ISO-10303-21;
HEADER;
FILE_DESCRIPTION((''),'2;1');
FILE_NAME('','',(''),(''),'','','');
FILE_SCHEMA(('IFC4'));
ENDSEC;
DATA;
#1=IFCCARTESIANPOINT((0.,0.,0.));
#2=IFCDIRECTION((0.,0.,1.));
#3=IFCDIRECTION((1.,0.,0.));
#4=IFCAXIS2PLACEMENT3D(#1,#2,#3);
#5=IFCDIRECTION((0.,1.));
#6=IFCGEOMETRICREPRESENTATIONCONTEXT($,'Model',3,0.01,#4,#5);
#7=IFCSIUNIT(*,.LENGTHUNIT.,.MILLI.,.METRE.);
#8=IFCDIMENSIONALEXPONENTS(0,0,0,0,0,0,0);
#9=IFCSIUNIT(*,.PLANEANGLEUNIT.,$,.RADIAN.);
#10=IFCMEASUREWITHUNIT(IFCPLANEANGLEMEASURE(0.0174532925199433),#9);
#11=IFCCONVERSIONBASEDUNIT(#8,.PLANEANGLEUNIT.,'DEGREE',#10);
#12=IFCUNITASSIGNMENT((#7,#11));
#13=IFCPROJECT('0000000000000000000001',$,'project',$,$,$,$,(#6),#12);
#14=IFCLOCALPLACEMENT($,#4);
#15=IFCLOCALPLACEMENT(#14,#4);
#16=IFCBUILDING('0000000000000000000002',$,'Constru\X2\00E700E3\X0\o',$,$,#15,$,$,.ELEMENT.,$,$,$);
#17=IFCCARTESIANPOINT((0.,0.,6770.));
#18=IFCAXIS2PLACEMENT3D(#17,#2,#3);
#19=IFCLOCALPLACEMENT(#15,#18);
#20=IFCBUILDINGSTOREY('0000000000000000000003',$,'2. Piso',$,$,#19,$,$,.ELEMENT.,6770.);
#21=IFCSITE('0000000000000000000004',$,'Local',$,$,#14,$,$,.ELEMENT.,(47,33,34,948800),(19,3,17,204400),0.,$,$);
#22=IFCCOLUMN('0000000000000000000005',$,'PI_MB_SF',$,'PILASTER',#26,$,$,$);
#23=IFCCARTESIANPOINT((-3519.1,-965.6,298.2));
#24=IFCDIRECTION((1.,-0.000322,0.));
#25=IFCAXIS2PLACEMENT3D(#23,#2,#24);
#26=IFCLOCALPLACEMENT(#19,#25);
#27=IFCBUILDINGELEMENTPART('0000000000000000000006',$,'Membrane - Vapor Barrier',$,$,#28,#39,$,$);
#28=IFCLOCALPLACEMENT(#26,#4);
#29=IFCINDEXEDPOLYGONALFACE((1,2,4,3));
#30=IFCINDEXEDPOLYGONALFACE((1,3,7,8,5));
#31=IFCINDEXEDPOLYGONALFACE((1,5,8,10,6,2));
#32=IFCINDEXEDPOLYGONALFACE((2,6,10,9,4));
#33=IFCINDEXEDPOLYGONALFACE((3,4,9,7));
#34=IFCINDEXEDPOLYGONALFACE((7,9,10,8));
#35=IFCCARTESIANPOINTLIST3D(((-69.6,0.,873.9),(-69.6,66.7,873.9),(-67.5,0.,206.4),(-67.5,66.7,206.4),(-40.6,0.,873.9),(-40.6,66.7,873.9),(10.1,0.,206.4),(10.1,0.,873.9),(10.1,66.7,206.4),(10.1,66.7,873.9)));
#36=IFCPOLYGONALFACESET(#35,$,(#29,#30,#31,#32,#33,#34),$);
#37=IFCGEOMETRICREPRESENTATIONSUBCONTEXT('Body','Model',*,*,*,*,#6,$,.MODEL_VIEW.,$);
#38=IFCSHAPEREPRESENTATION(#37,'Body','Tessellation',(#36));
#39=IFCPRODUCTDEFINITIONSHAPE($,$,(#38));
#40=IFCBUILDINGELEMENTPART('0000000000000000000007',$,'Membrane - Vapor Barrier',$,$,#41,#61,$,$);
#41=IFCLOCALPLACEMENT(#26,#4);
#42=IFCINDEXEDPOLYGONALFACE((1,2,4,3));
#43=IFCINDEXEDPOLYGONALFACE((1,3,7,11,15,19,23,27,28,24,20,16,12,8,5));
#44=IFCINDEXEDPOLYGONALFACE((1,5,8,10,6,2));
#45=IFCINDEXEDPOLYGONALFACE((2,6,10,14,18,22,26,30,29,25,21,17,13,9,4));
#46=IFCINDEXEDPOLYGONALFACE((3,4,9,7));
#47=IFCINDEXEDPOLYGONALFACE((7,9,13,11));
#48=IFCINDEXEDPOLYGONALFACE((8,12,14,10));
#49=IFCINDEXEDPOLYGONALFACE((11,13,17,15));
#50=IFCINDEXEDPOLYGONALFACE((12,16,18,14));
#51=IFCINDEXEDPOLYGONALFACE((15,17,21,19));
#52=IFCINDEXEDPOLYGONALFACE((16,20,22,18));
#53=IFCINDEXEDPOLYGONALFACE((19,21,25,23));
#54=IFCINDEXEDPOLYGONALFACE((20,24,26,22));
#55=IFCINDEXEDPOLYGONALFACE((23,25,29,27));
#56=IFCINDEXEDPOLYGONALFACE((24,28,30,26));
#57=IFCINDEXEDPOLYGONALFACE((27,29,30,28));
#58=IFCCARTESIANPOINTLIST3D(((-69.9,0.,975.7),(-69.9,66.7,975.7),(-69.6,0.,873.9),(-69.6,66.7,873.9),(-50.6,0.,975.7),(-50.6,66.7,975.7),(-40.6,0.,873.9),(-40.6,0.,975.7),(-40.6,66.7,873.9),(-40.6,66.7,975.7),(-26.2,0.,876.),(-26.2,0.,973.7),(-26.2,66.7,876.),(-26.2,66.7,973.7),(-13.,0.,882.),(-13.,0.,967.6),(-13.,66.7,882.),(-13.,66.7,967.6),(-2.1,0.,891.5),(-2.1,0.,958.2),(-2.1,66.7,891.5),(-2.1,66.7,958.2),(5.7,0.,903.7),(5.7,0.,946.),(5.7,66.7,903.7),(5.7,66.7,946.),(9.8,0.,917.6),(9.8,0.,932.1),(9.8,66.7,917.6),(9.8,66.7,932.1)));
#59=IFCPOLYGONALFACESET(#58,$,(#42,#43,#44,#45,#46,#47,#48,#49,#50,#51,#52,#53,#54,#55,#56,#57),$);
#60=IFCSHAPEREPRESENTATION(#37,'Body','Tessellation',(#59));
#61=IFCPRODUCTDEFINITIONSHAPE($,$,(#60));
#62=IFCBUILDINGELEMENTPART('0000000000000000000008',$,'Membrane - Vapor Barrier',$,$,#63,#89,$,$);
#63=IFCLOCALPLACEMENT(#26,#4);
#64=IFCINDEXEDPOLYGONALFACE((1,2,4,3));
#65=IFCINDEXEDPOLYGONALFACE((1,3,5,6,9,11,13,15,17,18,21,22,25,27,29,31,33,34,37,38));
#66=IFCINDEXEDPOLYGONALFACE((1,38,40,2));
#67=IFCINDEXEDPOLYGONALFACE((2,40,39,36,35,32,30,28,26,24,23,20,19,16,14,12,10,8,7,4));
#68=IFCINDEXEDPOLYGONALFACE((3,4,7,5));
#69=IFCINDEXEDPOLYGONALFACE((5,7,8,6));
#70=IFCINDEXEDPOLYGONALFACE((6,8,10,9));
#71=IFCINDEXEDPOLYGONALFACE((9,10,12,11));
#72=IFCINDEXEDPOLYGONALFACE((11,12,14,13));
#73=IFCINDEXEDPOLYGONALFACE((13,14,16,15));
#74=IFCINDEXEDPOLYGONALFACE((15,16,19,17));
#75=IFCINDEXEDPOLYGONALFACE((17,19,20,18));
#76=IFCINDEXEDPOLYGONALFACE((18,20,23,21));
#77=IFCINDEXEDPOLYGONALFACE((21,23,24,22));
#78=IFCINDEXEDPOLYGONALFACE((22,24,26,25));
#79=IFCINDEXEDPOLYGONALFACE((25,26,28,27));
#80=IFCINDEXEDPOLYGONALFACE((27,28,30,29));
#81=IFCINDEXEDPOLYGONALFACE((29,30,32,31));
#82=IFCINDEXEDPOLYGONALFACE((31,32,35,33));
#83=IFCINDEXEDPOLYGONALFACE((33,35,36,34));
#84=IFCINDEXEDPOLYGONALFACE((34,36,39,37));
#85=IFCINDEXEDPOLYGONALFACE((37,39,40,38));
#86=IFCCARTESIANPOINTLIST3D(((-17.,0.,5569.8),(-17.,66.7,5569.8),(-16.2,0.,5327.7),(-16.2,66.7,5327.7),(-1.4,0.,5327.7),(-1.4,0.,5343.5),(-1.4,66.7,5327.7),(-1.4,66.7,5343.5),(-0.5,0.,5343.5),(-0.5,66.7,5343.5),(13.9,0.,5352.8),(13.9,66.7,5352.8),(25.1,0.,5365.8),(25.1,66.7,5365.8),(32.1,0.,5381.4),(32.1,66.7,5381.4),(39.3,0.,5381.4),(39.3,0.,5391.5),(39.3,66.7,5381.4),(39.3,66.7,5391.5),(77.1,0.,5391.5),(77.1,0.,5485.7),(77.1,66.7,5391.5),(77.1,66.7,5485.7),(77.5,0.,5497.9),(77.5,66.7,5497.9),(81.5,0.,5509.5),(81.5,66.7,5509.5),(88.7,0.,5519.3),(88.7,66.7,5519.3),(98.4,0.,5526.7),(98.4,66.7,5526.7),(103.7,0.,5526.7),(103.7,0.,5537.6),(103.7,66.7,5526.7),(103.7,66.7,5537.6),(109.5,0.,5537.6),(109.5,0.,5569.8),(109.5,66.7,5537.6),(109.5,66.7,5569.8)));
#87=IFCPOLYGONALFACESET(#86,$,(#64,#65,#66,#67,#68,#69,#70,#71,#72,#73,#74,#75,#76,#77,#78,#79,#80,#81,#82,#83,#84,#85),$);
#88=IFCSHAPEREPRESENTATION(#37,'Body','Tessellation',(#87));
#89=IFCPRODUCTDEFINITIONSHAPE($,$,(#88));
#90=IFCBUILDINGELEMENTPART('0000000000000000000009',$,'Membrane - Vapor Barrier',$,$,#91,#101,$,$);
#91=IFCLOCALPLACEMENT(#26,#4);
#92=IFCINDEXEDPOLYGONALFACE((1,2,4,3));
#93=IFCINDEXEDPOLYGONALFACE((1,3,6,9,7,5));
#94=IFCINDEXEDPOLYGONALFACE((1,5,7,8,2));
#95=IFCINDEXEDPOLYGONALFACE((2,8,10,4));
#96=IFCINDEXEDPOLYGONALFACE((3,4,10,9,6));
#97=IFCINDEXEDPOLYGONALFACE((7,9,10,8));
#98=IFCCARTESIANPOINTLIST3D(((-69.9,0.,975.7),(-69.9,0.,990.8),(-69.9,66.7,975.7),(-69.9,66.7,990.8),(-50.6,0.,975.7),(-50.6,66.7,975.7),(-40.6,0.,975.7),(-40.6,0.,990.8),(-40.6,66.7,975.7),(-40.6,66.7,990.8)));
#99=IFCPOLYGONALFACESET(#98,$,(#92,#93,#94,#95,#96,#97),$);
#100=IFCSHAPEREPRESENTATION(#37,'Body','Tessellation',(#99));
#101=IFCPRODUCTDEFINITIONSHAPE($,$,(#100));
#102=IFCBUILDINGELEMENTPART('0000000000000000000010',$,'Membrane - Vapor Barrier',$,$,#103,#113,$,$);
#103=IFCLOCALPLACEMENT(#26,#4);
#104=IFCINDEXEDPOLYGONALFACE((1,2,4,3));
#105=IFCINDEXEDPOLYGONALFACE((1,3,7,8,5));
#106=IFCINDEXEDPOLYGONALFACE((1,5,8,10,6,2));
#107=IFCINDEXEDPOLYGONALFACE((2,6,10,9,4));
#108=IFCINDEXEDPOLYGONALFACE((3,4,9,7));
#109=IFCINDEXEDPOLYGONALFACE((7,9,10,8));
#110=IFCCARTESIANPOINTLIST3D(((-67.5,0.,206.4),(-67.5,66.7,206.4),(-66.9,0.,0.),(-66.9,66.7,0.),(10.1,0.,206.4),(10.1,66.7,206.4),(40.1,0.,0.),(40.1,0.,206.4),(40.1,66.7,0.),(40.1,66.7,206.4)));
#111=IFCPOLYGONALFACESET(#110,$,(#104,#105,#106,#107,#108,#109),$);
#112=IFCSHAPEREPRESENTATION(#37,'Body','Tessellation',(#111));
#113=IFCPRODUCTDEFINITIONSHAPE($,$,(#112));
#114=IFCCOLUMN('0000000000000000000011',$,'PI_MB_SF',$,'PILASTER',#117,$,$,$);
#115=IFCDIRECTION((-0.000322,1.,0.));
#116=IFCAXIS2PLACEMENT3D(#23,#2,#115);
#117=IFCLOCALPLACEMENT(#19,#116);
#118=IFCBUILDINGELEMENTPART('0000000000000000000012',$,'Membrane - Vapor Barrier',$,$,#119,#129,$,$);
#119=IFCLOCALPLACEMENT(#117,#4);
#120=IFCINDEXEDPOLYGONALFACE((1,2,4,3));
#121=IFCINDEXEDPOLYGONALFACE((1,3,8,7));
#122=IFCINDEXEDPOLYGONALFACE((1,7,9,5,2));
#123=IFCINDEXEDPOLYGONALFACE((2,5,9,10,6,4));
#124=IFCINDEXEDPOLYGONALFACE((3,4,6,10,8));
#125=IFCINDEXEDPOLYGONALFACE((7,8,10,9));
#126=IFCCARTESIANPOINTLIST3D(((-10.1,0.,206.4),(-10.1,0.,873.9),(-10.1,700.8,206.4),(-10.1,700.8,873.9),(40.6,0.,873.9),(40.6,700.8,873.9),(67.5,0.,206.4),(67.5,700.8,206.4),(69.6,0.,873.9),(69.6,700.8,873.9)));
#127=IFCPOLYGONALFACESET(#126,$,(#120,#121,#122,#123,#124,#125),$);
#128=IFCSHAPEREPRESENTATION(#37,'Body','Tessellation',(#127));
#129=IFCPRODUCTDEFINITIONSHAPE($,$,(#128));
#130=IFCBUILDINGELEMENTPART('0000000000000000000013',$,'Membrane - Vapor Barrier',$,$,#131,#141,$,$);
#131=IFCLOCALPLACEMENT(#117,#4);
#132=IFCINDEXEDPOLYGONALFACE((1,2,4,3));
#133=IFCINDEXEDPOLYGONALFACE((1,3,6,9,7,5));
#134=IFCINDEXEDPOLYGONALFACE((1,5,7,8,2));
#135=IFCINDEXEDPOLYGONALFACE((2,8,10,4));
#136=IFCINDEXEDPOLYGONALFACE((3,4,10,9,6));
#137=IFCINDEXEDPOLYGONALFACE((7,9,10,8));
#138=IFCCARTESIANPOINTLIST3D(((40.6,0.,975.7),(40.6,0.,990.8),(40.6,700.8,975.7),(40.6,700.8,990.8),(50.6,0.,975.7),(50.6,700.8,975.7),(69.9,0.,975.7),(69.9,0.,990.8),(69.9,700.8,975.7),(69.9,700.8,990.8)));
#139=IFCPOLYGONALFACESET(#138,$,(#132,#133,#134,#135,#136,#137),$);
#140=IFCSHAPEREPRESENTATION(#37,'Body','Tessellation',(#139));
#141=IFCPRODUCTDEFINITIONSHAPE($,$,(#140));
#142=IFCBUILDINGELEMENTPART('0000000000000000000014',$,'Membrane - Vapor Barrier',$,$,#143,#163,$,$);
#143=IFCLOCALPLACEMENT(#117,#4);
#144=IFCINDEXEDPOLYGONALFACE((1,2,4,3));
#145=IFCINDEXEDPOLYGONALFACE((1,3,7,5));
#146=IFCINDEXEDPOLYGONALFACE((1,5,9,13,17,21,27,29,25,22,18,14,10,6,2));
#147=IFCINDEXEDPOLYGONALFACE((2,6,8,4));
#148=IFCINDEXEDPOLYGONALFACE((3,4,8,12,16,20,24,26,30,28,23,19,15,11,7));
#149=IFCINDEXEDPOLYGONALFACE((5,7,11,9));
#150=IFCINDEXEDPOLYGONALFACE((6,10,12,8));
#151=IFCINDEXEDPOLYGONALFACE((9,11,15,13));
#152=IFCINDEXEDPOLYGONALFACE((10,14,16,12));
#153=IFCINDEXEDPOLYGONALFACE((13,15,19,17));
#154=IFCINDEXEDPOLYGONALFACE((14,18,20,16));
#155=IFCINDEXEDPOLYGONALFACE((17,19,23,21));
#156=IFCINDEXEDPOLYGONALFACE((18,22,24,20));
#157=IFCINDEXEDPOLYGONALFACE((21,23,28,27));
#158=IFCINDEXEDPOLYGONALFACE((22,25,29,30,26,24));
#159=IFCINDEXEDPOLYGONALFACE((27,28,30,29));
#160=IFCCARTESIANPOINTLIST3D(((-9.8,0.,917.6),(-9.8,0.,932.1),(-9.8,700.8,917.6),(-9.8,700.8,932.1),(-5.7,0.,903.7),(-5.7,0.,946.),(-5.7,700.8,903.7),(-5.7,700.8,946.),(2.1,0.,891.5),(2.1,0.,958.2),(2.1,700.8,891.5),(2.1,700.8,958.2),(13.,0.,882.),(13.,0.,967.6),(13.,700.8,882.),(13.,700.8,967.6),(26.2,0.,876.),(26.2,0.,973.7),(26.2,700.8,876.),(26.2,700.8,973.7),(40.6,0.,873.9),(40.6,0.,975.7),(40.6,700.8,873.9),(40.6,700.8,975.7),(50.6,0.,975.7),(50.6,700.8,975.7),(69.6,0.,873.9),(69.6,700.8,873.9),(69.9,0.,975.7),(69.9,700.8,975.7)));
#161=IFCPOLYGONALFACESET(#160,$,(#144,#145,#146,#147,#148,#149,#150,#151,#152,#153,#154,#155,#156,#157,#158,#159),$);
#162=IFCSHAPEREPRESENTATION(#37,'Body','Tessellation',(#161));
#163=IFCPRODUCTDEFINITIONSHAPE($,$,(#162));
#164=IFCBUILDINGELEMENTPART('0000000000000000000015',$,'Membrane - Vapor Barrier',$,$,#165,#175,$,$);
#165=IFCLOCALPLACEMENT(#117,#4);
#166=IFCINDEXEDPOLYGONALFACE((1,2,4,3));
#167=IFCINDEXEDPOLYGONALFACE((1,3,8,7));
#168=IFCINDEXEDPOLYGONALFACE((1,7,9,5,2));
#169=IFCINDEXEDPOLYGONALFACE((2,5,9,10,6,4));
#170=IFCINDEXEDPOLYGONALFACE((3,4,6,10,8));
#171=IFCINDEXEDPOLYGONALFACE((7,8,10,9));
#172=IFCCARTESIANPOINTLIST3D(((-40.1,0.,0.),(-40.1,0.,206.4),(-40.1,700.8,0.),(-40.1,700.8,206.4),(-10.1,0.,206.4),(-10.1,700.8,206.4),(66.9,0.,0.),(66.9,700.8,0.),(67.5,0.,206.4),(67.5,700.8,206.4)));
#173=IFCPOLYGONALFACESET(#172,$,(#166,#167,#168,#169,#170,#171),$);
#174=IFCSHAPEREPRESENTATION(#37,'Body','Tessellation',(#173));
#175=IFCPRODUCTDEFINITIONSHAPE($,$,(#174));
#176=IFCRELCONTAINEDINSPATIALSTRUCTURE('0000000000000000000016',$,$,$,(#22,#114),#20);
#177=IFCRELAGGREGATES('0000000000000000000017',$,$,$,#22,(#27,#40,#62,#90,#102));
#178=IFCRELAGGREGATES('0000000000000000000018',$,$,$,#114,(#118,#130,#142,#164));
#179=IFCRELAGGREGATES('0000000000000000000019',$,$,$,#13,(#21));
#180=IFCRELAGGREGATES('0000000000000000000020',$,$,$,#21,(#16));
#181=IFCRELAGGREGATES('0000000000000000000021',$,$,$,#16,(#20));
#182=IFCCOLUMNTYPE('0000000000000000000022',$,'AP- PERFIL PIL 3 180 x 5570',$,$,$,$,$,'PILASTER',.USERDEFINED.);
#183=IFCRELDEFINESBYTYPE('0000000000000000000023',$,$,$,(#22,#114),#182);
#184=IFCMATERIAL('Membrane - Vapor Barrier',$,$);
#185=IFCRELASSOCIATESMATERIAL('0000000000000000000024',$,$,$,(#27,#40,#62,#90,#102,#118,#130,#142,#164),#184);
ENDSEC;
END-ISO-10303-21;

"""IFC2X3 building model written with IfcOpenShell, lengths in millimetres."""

from ifc_helpers import new_model, entity, si_unit, converted_unit, point, direction, frame, frame_2d, origin_with_axes, place, context, subcontext, project, spatial, polyline, circle_curve, parameter, trimmed, segment, composite_curve, outline, extrude, material, type_object, element, aggregate, save


model = new_model("IFC2X3")

# Units and contexts
model_context = context("Model", 3, precision=0.01, world=origin_with_axes(), true_north=direction((0.0, 1.0)))
body_context = subcontext(model_context, "Body", "Model", "MODEL_VIEW")
ifc_project = project(units=[si_unit("LENGTHUNIT", "METRE", prefix="MILLI"), converted_unit("PLANEANGLEUNIT", "DEGREE", entity("IfcPlaneAngleMeasure", 0.0174532925199433), si_unit("PLANEANGLEUNIT", "RADIAN"), dimensions=[0, 0, 0, 0, 0, 0, 0])], contexts=[model_context])

# Site, building, storey
site_placement = place(None, origin_with_axes())
site = spatial("IfcSite", under=ifc_project, at=site_placement, Name="Local", CompositionType="ELEMENT", RefLatitude=(47, 33, 34, 948800), RefLongitude=(19, 3, 17, 204400), RefElevation=0.0)
building_placement = place(site_placement, origin_with_axes())
building = spatial("IfcBuilding", under=site, at=building_placement, Name="Construção", CompositionType="ELEMENT")
storey_placement = place(building_placement, frame((0.0, 0.0, 6770.0), z_axis=(0.0, 0.0, 1.0), x_axis=(1.0, 0.0, 0.0)))
storey = spatial("IfcBuildingStorey", under=building, at=storey_placement, Name="2. Piso", CompositionType="ELEMENT", Elevation=6770.0)

# Columns, building element parts
column_type = type_object("IfcColumnType", Name="AP- PERFIL PIL 3 180 x 5570", ElementType="PILASTER", PredefinedType="USERDEFINED")
column_1_placement = place(storey_placement, frame((-3519.1, -965.6, 298.2), z_axis=(0.0, 0.0, 1.0), x_axis=(1.0, -0.000322, 0.0)))
column_1 = element("IfcColumn", 1, at=column_1_placement, inside=storey, type_object=column_type, Name="PI_MB_SF", ObjectType="PILASTER")
ifc_material = material(Name="Membrane - Vapor Barrier")
building_element_part_1_placement = place(column_1_placement, origin_with_axes())
building_element_part_1 = element("IfcBuildingElementPart", 2, at=building_element_part_1_placement, material=ifc_material, Name="Membrane - Vapor Barrier", context=body_context, shape_type="SweptSolid", body=[
    extrude(outline(polyline([(-40.6, 873.9), (-69.6, 873.9), (-67.5, 206.4), (10.1, 206.4), (10.1, 873.9), (-40.6, 873.9)])), frame((0.0, 66.7, 0.0), z_axis=(0.0, -1.0, 0.0), x_axis=(1.0, 0.0, 0.0)), (0.0, 0.0, 1.0), 66.7),
])
building_element_part_2_placement = place(column_1_placement, origin_with_axes())
building_element_part_2 = element("IfcBuildingElementPart", 3, at=building_element_part_2_placement, material=ifc_material, Name="Membrane - Vapor Barrier", context=body_context, shape_type="SweptSolid", body=[
    extrude(outline(composite_curve([segment(polyline([(-50.6, 975.7), (-69.9, 975.7), (-69.6, 873.9), (-40.6, 873.9)]), True, "CONTINUOUS"), segment(trimmed(circle_curve(frame_2d((-40.6, 924.8), x_axis=(0.0, -1.0)), 50.9), [point((-40.6, 873.9)), parameter(0.0)], [point((-40.6, 975.7)), parameter(180.0)], True, "CARTESIAN"), True, "CONTINUOUS"), segment(polyline([(-40.6, 975.7), (-50.6, 975.7)]), True, "CONTINUOUS")], self_intersect=False)), frame((0.0, 66.7, 0.0), z_axis=(0.0, -1.0, 0.0), x_axis=(1.0, 0.0, 0.0)), (0.0, 0.0, 1.0), 66.7),
])
building_element_part_3_placement = place(column_1_placement, origin_with_axes())
building_element_part_3 = element("IfcBuildingElementPart", 4, at=building_element_part_3_placement, material=ifc_material, Name="Membrane - Vapor Barrier", context=body_context, shape_type="SweptSolid", body=[
    extrude(outline(composite_curve([segment(polyline([(-16.2, 5327.7), (-1.4, 5327.7), (-1.4, 5343.5), (-0.5, 5343.5)]), True, "CONTINUOUS"), segment(trimmed(circle_curve(frame_2d((-25.0, 5397.6), x_axis=(0.411627, -0.911352)), 59.4), [point((-0.5, 5343.5)), parameter(0.0)], [point((32.1, 5381.4)), parameter(49.79606)], True, "CARTESIAN"), True, "CONTINUOUS"), segment(polyline([(32.1, 5381.4), (39.3, 5381.4), (39.3, 5391.5), (77.1, 5391.5), (77.1, 5485.7)]), True, "CONTINUOUS"), segment(trimmed(circle_curve(frame_2d((118.3, 5490.3), x_axis=(-0.480333, 0.877086)), 41.5), [point((77.1, 5485.7)), parameter(67.594129)], [point((98.4, 5526.7)), parameter(0.0)], False, "CARTESIAN"), True, "CONTINUOUS"), segment(polyline([(98.4, 5526.7), (103.7, 5526.7), (103.7, 5537.6), (109.5, 5537.6), (109.5, 5569.8), (-17.0, 5569.8), (-16.2, 5327.7)]), True, "CONTINUOUS")], self_intersect=False)), frame((0.0, 66.7, 0.0), z_axis=(0.0, -1.0, 0.0), x_axis=(1.0, 0.0, 0.0)), (0.0, 0.0, 1.0), 66.7),
])
building_element_part_4_placement = place(column_1_placement, origin_with_axes())
building_element_part_4 = element("IfcBuildingElementPart", 5, at=building_element_part_4_placement, material=ifc_material, Name="Membrane - Vapor Barrier", context=body_context, shape_type="SweptSolid", body=[
    extrude(outline(polyline([(-69.9, 990.8), (-69.9, 975.7), (-50.6, 975.7), (-40.6, 975.7), (-40.6, 990.8), (-69.9, 990.8)])), frame((0.0, 66.7, 0.0), z_axis=(0.0, -1.0, 0.0), x_axis=(1.0, 0.0, 0.0)), (0.0, 0.0, 1.0), 66.7),
])
building_element_part_5_placement = place(column_1_placement, origin_with_axes())
building_element_part_5 = element("IfcBuildingElementPart", 6, at=building_element_part_5_placement, material=ifc_material, Name="Membrane - Vapor Barrier", context=body_context, shape_type="SweptSolid", body=[
    extrude(outline(polyline([(40.1, 0.0), (40.1, 206.4), (10.1, 206.4), (-67.5, 206.4), (-66.9, 0.0), (40.1, 0.0)])), frame((0.0, 66.7, 0.0), z_axis=(0.0, -1.0, 0.0), x_axis=(1.0, 0.0, 0.0)), (0.0, 0.0, 1.0), 66.7),
])
aggregate(column_1, [building_element_part_1, building_element_part_2, building_element_part_3, building_element_part_4, building_element_part_5])
column_2_placement = place(storey_placement, frame((-3519.1, -965.6, 298.2), z_axis=(0.0, 0.0, 1.0), x_axis=(-0.000322, 1.0, 0.0)))
column_2 = element("IfcColumn", 7, at=column_2_placement, inside=storey, type_object=column_type, Name="PI_MB_SF", ObjectType="PILASTER")
building_element_part_6_placement = place(column_2_placement, origin_with_axes())
building_element_part_6 = element("IfcBuildingElementPart", 8, at=building_element_part_6_placement, material=ifc_material, Name="Membrane - Vapor Barrier", context=body_context, shape_type="SweptSolid", body=[
    extrude(outline(polyline([(-40.6, 873.9), (-69.6, 873.9), (-67.5, 206.4), (10.1, 206.4), (10.1, 873.9), (-40.6, 873.9)])), frame((0.0, 700.8, 0.0), z_axis=(0.0, 1.0, 0.0), x_axis=(-1.0, 0.0, 0.0)), (0.0, 0.0, -1.0), 700.8),
])
building_element_part_7_placement = place(column_2_placement, origin_with_axes())
building_element_part_7 = element("IfcBuildingElementPart", 9, at=building_element_part_7_placement, material=ifc_material, Name="Membrane - Vapor Barrier", context=body_context, shape_type="SweptSolid", body=[
    extrude(outline(polyline([(-69.9, 990.8), (-69.9, 975.7), (-50.6, 975.7), (-40.6, 975.7), (-40.6, 990.8), (-69.9, 990.8)])), frame((0.0, 700.8, 0.0), z_axis=(0.0, 1.0, 0.0), x_axis=(-1.0, 0.0, 0.0)), (0.0, 0.0, -1.0), 700.8),
])
building_element_part_8_placement = place(column_2_placement, origin_with_axes())
building_element_part_8 = element("IfcBuildingElementPart", 10, at=building_element_part_8_placement, material=ifc_material, Name="Membrane - Vapor Barrier", context=body_context, shape_type="SweptSolid", body=[
    extrude(outline(composite_curve([segment(polyline([(-50.6, 975.7), (-69.9, 975.7), (-69.6, 873.9), (-40.6, 873.9)]), True, "CONTINUOUS"), segment(trimmed(circle_curve(frame_2d((-40.6, 924.8), x_axis=(0.0, -1.0)), 50.9), [point((-40.6, 873.9)), parameter(0.0)], [point((-40.6, 975.7)), parameter(180.0)], True, "CARTESIAN"), True, "CONTINUOUS"), segment(polyline([(-40.6, 975.7), (-50.6, 975.7)]), True, "CONTINUOUS")], self_intersect=False)), frame((0.0, 700.8, 0.0), z_axis=(0.0, 1.0, 0.0), x_axis=(-1.0, 0.0, 0.0)), (0.0, 0.0, -1.0), 700.8),
])
building_element_part_9_placement = place(column_2_placement, origin_with_axes())
building_element_part_9 = element("IfcBuildingElementPart", 11, at=building_element_part_9_placement, material=ifc_material, Name="Membrane - Vapor Barrier", context=body_context, shape_type="SweptSolid", body=[
    extrude(outline(polyline([(40.1, 0.0), (40.1, 206.4), (10.1, 206.4), (-67.5, 206.4), (-66.9, 0.0), (40.1, 0.0)])), frame((0.0, 700.8, 0.0), z_axis=(0.0, 1.0, 0.0), x_axis=(-1.0, 0.0, 0.0)), (0.0, 0.0, -1.0), 700.8),
])
aggregate(column_2, [building_element_part_6, building_element_part_7, building_element_part_8, building_element_part_9])

save(model, "model.ifc")
